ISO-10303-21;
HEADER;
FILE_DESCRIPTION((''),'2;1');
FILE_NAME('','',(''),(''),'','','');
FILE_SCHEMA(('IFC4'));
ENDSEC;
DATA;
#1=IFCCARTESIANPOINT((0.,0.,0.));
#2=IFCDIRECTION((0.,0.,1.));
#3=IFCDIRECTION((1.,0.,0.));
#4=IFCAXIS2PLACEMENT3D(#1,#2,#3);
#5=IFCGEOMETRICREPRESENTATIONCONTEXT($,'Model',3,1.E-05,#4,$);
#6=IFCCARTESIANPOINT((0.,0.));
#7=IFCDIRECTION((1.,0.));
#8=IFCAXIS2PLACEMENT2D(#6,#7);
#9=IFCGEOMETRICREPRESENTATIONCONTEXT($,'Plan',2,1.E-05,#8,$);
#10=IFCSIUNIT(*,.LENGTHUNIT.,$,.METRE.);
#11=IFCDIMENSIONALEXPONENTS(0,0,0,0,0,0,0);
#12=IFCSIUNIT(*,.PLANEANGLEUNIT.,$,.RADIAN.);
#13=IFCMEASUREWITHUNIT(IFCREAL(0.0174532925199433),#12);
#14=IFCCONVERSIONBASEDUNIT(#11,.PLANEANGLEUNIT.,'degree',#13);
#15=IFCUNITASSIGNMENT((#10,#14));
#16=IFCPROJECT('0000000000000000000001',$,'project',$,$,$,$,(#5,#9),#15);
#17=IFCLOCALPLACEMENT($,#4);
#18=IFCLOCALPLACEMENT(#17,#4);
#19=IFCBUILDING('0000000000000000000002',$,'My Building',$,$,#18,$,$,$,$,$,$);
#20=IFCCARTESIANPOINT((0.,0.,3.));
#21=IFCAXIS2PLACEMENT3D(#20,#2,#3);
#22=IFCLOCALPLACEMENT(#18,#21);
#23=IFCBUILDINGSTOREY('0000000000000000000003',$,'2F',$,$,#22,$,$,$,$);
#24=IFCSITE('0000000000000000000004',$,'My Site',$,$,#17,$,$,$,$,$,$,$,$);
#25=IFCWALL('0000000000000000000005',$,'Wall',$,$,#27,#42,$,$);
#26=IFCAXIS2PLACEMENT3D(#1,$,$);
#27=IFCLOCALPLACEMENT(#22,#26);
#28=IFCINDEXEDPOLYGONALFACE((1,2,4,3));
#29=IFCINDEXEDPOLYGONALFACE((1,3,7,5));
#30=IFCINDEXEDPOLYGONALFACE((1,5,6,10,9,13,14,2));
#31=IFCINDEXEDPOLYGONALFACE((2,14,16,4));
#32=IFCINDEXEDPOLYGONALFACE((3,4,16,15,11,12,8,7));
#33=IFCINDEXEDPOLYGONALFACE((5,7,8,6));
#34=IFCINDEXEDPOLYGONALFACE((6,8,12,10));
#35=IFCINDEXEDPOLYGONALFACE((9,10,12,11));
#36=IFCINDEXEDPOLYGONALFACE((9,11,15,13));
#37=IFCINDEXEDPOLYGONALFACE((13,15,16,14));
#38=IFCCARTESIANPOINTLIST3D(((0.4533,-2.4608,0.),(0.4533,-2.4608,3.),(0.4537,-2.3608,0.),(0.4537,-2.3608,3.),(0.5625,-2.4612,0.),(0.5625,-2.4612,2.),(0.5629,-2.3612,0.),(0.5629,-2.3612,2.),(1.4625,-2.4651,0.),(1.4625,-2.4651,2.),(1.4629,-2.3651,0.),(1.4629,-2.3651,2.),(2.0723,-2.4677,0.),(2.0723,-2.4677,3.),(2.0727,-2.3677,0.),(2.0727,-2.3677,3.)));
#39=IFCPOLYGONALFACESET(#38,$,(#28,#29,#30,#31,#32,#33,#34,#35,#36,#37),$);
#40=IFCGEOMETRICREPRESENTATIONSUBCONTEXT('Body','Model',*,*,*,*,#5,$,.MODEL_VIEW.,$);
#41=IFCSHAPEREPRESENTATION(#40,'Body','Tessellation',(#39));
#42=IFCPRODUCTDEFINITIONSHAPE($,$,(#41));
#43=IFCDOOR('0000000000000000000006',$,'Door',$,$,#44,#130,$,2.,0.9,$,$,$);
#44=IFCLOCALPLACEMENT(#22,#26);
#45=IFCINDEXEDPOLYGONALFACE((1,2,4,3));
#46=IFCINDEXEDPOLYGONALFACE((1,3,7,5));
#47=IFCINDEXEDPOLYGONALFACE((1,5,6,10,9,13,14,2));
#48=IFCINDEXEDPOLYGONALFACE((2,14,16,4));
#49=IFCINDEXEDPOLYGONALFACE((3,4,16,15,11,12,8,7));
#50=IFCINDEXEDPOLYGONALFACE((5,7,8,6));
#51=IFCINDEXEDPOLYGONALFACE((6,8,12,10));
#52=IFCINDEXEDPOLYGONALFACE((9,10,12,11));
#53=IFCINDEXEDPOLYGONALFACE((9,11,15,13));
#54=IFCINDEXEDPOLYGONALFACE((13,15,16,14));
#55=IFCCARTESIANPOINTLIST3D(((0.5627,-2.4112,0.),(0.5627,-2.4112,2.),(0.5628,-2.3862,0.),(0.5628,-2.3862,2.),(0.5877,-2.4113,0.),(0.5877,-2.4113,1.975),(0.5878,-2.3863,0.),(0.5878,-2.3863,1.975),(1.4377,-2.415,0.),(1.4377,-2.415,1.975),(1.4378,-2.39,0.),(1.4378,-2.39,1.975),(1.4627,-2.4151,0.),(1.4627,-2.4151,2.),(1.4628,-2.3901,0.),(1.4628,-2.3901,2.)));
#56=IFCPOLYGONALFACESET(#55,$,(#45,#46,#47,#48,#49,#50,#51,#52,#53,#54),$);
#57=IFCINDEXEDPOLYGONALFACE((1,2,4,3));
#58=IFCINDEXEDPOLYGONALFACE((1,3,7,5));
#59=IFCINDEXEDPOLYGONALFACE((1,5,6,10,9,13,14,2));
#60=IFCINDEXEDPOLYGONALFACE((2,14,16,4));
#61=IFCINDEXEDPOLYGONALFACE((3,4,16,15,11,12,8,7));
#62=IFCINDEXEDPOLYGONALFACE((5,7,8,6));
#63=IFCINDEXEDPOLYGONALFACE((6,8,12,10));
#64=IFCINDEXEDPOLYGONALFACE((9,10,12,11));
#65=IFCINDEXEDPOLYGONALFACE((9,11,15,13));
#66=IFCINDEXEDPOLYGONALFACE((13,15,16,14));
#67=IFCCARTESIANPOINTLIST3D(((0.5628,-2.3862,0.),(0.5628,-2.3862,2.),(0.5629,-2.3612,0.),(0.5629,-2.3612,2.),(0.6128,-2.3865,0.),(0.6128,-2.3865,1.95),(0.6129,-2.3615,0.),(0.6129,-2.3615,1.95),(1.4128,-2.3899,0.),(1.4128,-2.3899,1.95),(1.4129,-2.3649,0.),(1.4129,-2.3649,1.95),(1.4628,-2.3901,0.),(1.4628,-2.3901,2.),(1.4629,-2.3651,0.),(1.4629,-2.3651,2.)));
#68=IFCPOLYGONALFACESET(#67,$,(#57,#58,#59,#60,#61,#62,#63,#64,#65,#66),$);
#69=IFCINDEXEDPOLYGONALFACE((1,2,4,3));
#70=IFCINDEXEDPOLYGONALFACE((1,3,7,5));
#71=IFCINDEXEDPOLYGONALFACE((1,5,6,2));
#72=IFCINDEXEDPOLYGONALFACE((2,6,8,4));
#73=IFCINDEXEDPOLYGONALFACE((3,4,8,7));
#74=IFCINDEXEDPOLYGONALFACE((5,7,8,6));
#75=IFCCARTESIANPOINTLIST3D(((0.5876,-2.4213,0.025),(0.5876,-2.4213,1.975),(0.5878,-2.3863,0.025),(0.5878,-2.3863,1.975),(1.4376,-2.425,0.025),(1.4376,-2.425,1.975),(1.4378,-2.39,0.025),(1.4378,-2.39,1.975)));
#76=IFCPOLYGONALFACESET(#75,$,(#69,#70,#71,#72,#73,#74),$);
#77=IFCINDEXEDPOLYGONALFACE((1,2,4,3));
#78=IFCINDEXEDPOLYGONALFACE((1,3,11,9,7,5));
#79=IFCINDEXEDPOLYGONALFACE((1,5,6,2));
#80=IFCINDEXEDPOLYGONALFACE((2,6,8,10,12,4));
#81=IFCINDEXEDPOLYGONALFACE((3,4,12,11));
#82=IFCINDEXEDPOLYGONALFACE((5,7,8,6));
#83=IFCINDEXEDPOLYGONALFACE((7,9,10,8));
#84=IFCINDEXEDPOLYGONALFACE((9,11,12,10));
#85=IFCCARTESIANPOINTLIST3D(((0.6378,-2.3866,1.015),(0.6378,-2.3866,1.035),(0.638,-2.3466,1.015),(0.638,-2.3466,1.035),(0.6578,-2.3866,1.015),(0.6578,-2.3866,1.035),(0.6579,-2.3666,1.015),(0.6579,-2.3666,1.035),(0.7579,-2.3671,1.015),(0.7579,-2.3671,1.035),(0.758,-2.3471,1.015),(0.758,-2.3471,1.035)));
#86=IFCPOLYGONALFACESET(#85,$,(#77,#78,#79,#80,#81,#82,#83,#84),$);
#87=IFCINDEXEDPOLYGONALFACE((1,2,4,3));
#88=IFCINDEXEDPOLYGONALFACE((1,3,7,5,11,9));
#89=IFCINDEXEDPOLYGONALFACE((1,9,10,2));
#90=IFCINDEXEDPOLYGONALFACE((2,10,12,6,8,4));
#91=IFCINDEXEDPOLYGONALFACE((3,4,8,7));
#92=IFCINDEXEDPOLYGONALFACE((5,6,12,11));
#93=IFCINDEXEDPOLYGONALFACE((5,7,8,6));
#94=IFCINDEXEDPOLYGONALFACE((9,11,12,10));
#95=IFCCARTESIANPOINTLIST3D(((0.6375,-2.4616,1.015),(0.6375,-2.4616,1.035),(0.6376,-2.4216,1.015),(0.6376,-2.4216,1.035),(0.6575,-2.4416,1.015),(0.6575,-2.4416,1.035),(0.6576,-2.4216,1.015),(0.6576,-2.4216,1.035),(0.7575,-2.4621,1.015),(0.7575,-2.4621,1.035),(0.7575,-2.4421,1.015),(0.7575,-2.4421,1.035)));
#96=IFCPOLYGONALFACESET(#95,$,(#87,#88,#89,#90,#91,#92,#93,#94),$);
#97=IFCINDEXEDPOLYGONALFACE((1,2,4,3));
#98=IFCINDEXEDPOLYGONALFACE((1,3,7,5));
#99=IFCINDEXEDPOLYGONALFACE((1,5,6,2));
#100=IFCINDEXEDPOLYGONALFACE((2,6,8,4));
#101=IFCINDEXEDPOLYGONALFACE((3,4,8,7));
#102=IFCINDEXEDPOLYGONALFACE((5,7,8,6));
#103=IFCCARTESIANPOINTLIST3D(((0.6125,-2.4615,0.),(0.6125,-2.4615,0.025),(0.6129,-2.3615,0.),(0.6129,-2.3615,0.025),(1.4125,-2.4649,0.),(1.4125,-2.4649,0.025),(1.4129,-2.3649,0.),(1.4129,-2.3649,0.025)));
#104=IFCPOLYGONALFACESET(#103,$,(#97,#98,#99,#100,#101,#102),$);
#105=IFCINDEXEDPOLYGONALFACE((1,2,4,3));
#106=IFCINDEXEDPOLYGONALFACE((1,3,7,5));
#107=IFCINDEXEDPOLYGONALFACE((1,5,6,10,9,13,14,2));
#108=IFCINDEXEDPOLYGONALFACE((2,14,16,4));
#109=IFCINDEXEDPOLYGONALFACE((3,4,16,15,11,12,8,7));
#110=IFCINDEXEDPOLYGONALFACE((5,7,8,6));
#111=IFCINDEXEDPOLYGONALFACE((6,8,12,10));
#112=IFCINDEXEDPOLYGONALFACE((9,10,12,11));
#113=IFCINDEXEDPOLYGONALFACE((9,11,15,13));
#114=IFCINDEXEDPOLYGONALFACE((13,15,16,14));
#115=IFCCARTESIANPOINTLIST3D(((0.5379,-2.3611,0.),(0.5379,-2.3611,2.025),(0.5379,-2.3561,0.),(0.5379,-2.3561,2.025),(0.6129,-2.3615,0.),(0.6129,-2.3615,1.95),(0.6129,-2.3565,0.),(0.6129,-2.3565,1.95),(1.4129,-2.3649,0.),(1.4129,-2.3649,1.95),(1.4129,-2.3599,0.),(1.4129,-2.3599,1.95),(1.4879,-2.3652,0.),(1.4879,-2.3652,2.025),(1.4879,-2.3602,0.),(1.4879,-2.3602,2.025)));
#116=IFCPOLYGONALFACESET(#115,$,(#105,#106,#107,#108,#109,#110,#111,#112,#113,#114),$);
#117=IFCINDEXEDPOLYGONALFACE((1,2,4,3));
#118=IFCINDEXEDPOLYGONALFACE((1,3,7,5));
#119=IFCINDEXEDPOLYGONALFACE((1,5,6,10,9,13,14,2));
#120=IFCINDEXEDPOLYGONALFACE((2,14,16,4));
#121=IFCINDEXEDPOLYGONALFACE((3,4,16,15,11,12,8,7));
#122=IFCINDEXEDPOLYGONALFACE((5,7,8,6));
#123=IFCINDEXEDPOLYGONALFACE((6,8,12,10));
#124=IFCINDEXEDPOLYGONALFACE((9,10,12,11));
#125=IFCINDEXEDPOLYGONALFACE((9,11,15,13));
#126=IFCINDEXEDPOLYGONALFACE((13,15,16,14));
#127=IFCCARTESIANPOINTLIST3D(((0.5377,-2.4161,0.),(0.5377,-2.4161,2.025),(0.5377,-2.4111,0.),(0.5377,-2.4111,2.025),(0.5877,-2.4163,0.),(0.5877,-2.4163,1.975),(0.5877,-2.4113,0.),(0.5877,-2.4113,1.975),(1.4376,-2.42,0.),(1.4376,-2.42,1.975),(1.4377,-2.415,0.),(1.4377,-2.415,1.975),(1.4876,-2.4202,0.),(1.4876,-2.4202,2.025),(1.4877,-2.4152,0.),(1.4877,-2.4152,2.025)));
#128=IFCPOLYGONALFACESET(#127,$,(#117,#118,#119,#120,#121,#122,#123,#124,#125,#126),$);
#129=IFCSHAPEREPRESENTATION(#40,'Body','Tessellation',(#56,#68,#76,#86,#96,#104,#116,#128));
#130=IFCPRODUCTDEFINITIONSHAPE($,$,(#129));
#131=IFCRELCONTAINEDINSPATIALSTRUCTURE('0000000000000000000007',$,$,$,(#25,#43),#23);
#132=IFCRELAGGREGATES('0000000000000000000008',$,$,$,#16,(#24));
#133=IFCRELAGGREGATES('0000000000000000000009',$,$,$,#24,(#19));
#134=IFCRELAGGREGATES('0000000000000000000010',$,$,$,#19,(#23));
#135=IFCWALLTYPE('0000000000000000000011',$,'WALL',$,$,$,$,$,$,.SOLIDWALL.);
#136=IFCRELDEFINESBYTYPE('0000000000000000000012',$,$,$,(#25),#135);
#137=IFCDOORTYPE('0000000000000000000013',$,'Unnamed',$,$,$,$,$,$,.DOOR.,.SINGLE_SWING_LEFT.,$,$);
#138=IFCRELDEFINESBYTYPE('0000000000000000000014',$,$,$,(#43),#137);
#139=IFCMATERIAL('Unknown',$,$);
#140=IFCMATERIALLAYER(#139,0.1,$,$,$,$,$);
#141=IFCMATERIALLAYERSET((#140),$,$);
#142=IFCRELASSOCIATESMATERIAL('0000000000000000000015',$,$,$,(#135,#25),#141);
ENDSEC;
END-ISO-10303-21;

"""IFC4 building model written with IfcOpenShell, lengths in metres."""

from ifc_helpers import new_model, entity, si_unit, converted_unit, frame, origin_with_axes, origin_2d_with_axis, place, context, subcontext, project, spatial, line, indexed_curve, outline, extrude, shape, source, transform, mapped, material, layer, layer_set, layer_usage, type_object, type_shapes, element, fill, save


model = new_model("IFC4")

# Units and contexts
model_context = context("Model", 3, precision=1e-05, world=origin_with_axes())
plan_context = context("Plan", 2, precision=1e-05, world=origin_2d_with_axis())
body_context_1 = subcontext(model_context, "Body", "Model", "MODEL_VIEW")
body_context_2 = subcontext(plan_context, "Body", "Plan", "PLAN_VIEW")
ifc_project = project(units=[si_unit("LENGTHUNIT", "METRE"), converted_unit("PLANEANGLEUNIT", "degree", entity("IfcReal", 0.0174532925199433), si_unit("PLANEANGLEUNIT", "RADIAN"), dimensions=[0, 0, 0, 0, 0, 0, 0])], contexts=[model_context, plan_context])

# Site, building, storey
site_placement = place(None, origin_with_axes())
site = spatial("IfcSite", under=ifc_project, at=site_placement, Name="My Site")
building_placement = place(site_placement, origin_with_axes())
building = spatial("IfcBuilding", under=site, at=building_placement, Name="My Building")
storey_placement = place(building_placement, frame((0.0, 0.0, 3.0), z_axis=(0.0, 0.0, 1.0), x_axis=(1.0, 0.0, 0.0)))
storey = spatial("IfcBuildingStorey", under=building, at=storey_placement, Name="2F")

# Shared definitions
ifc_material = material(Name="Unknown")

# Shared definitions
ifc_layer_1 = layer(ifc_material, 0.1)
ifc_layer_set_1 = layer_set([ifc_layer_1])
wall_type = type_object("IfcWallType", Name="WALL", PredefinedType="SOLIDWALL", material=ifc_layer_set_1)

# Shared definitions
shared_shape_1 = source(origin_with_axes(), body_context_1, "Body", "SweptSolid", [
    extrude(outline(indexed_curve([(0.0, 0.0), (0.9, 0.0), (0.9, 2.0), (0.0, 2.0)], segments=[line(1, 2, 3, 4, 1)])), frame((0.0, -0.6, 0.0), z_axis=(0.0, -1.0, 0.0), x_axis=(1.0, 0.0, 0.0)), (0.0, 0.0, -1.0), 1.2),
])
door_type = type_object("IfcDoorType", Name="Unnamed", OperationType="SINGLE_SWING_LEFT", PredefinedType="DOOR")
shared_shape_2 = source(origin_with_axes(), body_context_1, "Body", "SweptSolid", [
    extrude(outline(indexed_curve([(0.0, 0.0), (0.0, 2.0), (0.9, 2.0), (0.9, 0.0), (0.875, 0.0), (0.875, 1.975), (0.025, 1.975), (0.025, 0.0)], segments=[line(1, 2, 3, 4, 5, 6, 7, 8, 1)])), frame((0.0, 0.025, 0.0), z_axis=(0.0, -1.0, 0.0), x_axis=(1.0, 0.0, 0.0)), (0.0, 0.0, -1.0), 0.025),
    extrude(outline(indexed_curve([(0.0, 0.0), (0.0, 2.0), (0.9, 2.0), (0.9, 0.0), (0.85, 0.0), (0.85, 1.95), (0.05, 1.95), (0.05, 0.0)], segments=[line(1, 2, 3, 4, 5, 6, 7, 8, 1)])), frame((0.0, 0.0, 0.0), z_axis=(0.0, -1.0, 0.0), x_axis=(1.0, 0.0, 0.0)), (0.0, 0.0, -1.0), 0.025),
    extrude(outline(indexed_curve([(0.0, 0.0), (0.85, 0.0), (0.85, 0.035), (0.0, 0.035)], segments=[line(1, 2, 3, 4, 1)])), frame((0.025, 0.025, 0.025), z_axis=(0.0, 0.0, 1.0), x_axis=(1.0, 0.0, 0.0)), (0.0, 0.0, 1.0), 1.95),
    extrude(outline(indexed_curve([(0.0, 0.0), (0.0, -0.04), (-0.12, -0.04), (-0.12, -0.02), (-0.02, -0.02), (-0.02, 0.0)], segments=[line(1, 2, 3, 4, 5, 6, 1)])), frame((0.825, 0.025, 1.015), z_axis=(0.0, 0.0, 1.0), x_axis=(1.0, 0.0, 0.0)), (0.0, 0.0, 1.0), 0.02),
    extrude(outline(indexed_curve([(0.0, 0.0), (0.0, 0.04), (-0.12, 0.04), (-0.12, 0.02), (-0.02, 0.02), (-0.02, 0.0)], segments=[line(1, 2, 3, 4, 5, 6, 1)])), frame((0.825, 0.06, 1.015), z_axis=(0.0, 0.0, 1.0), x_axis=(1.0, 0.0, 0.0)), (0.0, 0.0, 1.0), 0.02),
    extrude(outline(indexed_curve([(0.0, 0.0), (0.8, 0.0), (0.8, 0.1), (0.0, 0.1)], segments=[line(1, 2, 3, 4, 1)])), frame((0.05, 0.0, 0.0), z_axis=(0.0, 0.0, 1.0), x_axis=(1.0, 0.0, 0.0)), (0.0, 0.0, 1.0), 0.025),
    extrude(outline(indexed_curve([(0.0, 0.0), (0.0, 2.025), (0.95, 2.025), (0.95, 0.0), (0.875, 0.0), (0.875, 1.95), (0.075, 1.95), (0.075, 0.0)], segments=[line(1, 2, 3, 4, 5, 6, 7, 8, 1)])), frame((-0.025, -0.005, 0.0), z_axis=(0.0, -1.0, 0.0), x_axis=(1.0, 0.0, 0.0)), (0.0, 0.0, -1.0), 0.005),
    extrude(outline(indexed_curve([(0.0, 0.0), (0.0, 2.025), (0.95, 2.025), (0.95, 0.0), (0.9, 0.0), (0.9, 1.975), (0.05, 1.975), (0.05, 0.0)], segments=[line(1, 2, 3, 4, 5, 6, 7, 8, 1)])), frame((-0.025, 0.05, 0.0), z_axis=(0.0, -1.0, 0.0), x_axis=(1.0, 0.0, 0.0)), (0.0, 0.0, -1.0), 0.005),
])
shared_shape_3 = source(origin_with_axes(), body_context_2, "Body", "Curve2D", [
    entity("IfcIndexedPolyCurve", entity("IfcCartesianPointList2D", [[0.0, 0.0], [0.0, 0.05], [0.025, 0.05], [0.025, 0.025], [0.05, 0.025], [0.05, 0.0]]), [entity("IfcLineIndex", [1, 2, 3, 4, 5, 6, 1])]),
    entity("IfcIndexedPolyCurve", entity("IfcCartesianPointList2D", [[0.9, 0.0], [0.9, 0.05], [0.875, 0.05], [0.875, 0.025], [0.85, 0.025], [0.85, 0.0]]), [entity("IfcLineIndex", [1, 2, 3, 4, 5, 6, 1])]),
    entity("IfcTrimmedCurve", entity("IfcEllipse", entity("IfcAxis2Placement2D", entity("IfcCartesianPoint", [0.06, 0.05]), entity("IfcDirection", [1.0, 0.0])), 0.815, 0.85), [entity("IfcCartesianPoint", [0.875, 0.05])], [entity("IfcCartesianPoint", [0.06, 0.9])], True, "CARTESIAN"),
    entity("IfcIndexedPolyCurve", entity("IfcCartesianPointList2D", [[0.025, 0.05], [0.06, 0.05], [0.06, 0.9], [0.025, 0.9]]), [entity("IfcLineIndex", [1, 2, 3, 4, 1])]),
])
type_shapes(door_type, [shared_shape_2, shared_shape_3])

# Wall, opening, door
ifc_layer_usage_1 = layer_usage(ifc_layer_set_1, "AXIS2", "POSITIVE", 0.0)
wall_1_placement = place(storey_placement, frame((2.0727, -2.3677, 0.0), z_axis=(0.0, 0.0, 1.0), x_axis=(-0.999991, 0.00431, 0.0)))
wall_1 = element("IfcWall", 1, at=wall_1_placement, inside=storey, type_object=wall_type, material=ifc_layer_usage_1, Name="Wall", context=body_context_1, shape_type="SweptSolid", body=[
    extrude(outline(indexed_curve([(0.0, 0.0), (0.0, 0.1), (1.619, 0.1), (1.619, 0.0)], segments=[line(1, 2, 3, 4, 1)])), origin_with_axes(), (0.0, 0.0, 1.0), 3.0),
])
opening_1_placement = place(wall_1_placement, frame((0.6098, 0.0, 0.0), z_axis=(0.0, 0.0, 1.0), x_axis=(1.0, 0.0, 0.0)))
opening_1 = element("IfcOpeningElement", 2, at=opening_1_placement, cuts=wall_1, PredefinedType="OPENING", context=body_context_1, shape_type="MappedRepresentation", body=[
    mapped(shared_shape_1, transform((0.0, 0.0, 0.0), x_axis=(1.0, 0.0, 0.0), y_axis=(0.0, 1.0, 0.0), z_axis=(0.0, 0.0, 1.0), scale=1.0)),
])
door_1_placement = place(opening_1_placement, frame((0.0, 0.0, 0.0), z_axis=(0.0, 0.0, 1.0), x_axis=(1.0, 0.0, 0.0)))
door_1 = element("IfcDoor", 3, at=door_1_placement, inside=storey, type_object=door_type, Name="Door", OverallHeight=2.0, OverallWidth=0.9, shapes=[
    shape(body_context_1, "Body", "MappedRepresentation", [mapped(shared_shape_2, transform((0.0, 0.0, 0.0), x_axis=(1.0, 0.0, 0.0), y_axis=(0.0, 1.0, 0.0), z_axis=(0.0, 0.0, 1.0), scale=1.0))]),
    shape(body_context_2, "Body", "MappedRepresentation", [mapped(shared_shape_3, transform((0.0, 0.0, 0.0), x_axis=(1.0, 0.0, 0.0), y_axis=(0.0, 1.0, 0.0), z_axis=(0.0, 0.0, 1.0), scale=1.0))]),
])
fill(opening_1, door_1)

save(model, "model.ifc")
